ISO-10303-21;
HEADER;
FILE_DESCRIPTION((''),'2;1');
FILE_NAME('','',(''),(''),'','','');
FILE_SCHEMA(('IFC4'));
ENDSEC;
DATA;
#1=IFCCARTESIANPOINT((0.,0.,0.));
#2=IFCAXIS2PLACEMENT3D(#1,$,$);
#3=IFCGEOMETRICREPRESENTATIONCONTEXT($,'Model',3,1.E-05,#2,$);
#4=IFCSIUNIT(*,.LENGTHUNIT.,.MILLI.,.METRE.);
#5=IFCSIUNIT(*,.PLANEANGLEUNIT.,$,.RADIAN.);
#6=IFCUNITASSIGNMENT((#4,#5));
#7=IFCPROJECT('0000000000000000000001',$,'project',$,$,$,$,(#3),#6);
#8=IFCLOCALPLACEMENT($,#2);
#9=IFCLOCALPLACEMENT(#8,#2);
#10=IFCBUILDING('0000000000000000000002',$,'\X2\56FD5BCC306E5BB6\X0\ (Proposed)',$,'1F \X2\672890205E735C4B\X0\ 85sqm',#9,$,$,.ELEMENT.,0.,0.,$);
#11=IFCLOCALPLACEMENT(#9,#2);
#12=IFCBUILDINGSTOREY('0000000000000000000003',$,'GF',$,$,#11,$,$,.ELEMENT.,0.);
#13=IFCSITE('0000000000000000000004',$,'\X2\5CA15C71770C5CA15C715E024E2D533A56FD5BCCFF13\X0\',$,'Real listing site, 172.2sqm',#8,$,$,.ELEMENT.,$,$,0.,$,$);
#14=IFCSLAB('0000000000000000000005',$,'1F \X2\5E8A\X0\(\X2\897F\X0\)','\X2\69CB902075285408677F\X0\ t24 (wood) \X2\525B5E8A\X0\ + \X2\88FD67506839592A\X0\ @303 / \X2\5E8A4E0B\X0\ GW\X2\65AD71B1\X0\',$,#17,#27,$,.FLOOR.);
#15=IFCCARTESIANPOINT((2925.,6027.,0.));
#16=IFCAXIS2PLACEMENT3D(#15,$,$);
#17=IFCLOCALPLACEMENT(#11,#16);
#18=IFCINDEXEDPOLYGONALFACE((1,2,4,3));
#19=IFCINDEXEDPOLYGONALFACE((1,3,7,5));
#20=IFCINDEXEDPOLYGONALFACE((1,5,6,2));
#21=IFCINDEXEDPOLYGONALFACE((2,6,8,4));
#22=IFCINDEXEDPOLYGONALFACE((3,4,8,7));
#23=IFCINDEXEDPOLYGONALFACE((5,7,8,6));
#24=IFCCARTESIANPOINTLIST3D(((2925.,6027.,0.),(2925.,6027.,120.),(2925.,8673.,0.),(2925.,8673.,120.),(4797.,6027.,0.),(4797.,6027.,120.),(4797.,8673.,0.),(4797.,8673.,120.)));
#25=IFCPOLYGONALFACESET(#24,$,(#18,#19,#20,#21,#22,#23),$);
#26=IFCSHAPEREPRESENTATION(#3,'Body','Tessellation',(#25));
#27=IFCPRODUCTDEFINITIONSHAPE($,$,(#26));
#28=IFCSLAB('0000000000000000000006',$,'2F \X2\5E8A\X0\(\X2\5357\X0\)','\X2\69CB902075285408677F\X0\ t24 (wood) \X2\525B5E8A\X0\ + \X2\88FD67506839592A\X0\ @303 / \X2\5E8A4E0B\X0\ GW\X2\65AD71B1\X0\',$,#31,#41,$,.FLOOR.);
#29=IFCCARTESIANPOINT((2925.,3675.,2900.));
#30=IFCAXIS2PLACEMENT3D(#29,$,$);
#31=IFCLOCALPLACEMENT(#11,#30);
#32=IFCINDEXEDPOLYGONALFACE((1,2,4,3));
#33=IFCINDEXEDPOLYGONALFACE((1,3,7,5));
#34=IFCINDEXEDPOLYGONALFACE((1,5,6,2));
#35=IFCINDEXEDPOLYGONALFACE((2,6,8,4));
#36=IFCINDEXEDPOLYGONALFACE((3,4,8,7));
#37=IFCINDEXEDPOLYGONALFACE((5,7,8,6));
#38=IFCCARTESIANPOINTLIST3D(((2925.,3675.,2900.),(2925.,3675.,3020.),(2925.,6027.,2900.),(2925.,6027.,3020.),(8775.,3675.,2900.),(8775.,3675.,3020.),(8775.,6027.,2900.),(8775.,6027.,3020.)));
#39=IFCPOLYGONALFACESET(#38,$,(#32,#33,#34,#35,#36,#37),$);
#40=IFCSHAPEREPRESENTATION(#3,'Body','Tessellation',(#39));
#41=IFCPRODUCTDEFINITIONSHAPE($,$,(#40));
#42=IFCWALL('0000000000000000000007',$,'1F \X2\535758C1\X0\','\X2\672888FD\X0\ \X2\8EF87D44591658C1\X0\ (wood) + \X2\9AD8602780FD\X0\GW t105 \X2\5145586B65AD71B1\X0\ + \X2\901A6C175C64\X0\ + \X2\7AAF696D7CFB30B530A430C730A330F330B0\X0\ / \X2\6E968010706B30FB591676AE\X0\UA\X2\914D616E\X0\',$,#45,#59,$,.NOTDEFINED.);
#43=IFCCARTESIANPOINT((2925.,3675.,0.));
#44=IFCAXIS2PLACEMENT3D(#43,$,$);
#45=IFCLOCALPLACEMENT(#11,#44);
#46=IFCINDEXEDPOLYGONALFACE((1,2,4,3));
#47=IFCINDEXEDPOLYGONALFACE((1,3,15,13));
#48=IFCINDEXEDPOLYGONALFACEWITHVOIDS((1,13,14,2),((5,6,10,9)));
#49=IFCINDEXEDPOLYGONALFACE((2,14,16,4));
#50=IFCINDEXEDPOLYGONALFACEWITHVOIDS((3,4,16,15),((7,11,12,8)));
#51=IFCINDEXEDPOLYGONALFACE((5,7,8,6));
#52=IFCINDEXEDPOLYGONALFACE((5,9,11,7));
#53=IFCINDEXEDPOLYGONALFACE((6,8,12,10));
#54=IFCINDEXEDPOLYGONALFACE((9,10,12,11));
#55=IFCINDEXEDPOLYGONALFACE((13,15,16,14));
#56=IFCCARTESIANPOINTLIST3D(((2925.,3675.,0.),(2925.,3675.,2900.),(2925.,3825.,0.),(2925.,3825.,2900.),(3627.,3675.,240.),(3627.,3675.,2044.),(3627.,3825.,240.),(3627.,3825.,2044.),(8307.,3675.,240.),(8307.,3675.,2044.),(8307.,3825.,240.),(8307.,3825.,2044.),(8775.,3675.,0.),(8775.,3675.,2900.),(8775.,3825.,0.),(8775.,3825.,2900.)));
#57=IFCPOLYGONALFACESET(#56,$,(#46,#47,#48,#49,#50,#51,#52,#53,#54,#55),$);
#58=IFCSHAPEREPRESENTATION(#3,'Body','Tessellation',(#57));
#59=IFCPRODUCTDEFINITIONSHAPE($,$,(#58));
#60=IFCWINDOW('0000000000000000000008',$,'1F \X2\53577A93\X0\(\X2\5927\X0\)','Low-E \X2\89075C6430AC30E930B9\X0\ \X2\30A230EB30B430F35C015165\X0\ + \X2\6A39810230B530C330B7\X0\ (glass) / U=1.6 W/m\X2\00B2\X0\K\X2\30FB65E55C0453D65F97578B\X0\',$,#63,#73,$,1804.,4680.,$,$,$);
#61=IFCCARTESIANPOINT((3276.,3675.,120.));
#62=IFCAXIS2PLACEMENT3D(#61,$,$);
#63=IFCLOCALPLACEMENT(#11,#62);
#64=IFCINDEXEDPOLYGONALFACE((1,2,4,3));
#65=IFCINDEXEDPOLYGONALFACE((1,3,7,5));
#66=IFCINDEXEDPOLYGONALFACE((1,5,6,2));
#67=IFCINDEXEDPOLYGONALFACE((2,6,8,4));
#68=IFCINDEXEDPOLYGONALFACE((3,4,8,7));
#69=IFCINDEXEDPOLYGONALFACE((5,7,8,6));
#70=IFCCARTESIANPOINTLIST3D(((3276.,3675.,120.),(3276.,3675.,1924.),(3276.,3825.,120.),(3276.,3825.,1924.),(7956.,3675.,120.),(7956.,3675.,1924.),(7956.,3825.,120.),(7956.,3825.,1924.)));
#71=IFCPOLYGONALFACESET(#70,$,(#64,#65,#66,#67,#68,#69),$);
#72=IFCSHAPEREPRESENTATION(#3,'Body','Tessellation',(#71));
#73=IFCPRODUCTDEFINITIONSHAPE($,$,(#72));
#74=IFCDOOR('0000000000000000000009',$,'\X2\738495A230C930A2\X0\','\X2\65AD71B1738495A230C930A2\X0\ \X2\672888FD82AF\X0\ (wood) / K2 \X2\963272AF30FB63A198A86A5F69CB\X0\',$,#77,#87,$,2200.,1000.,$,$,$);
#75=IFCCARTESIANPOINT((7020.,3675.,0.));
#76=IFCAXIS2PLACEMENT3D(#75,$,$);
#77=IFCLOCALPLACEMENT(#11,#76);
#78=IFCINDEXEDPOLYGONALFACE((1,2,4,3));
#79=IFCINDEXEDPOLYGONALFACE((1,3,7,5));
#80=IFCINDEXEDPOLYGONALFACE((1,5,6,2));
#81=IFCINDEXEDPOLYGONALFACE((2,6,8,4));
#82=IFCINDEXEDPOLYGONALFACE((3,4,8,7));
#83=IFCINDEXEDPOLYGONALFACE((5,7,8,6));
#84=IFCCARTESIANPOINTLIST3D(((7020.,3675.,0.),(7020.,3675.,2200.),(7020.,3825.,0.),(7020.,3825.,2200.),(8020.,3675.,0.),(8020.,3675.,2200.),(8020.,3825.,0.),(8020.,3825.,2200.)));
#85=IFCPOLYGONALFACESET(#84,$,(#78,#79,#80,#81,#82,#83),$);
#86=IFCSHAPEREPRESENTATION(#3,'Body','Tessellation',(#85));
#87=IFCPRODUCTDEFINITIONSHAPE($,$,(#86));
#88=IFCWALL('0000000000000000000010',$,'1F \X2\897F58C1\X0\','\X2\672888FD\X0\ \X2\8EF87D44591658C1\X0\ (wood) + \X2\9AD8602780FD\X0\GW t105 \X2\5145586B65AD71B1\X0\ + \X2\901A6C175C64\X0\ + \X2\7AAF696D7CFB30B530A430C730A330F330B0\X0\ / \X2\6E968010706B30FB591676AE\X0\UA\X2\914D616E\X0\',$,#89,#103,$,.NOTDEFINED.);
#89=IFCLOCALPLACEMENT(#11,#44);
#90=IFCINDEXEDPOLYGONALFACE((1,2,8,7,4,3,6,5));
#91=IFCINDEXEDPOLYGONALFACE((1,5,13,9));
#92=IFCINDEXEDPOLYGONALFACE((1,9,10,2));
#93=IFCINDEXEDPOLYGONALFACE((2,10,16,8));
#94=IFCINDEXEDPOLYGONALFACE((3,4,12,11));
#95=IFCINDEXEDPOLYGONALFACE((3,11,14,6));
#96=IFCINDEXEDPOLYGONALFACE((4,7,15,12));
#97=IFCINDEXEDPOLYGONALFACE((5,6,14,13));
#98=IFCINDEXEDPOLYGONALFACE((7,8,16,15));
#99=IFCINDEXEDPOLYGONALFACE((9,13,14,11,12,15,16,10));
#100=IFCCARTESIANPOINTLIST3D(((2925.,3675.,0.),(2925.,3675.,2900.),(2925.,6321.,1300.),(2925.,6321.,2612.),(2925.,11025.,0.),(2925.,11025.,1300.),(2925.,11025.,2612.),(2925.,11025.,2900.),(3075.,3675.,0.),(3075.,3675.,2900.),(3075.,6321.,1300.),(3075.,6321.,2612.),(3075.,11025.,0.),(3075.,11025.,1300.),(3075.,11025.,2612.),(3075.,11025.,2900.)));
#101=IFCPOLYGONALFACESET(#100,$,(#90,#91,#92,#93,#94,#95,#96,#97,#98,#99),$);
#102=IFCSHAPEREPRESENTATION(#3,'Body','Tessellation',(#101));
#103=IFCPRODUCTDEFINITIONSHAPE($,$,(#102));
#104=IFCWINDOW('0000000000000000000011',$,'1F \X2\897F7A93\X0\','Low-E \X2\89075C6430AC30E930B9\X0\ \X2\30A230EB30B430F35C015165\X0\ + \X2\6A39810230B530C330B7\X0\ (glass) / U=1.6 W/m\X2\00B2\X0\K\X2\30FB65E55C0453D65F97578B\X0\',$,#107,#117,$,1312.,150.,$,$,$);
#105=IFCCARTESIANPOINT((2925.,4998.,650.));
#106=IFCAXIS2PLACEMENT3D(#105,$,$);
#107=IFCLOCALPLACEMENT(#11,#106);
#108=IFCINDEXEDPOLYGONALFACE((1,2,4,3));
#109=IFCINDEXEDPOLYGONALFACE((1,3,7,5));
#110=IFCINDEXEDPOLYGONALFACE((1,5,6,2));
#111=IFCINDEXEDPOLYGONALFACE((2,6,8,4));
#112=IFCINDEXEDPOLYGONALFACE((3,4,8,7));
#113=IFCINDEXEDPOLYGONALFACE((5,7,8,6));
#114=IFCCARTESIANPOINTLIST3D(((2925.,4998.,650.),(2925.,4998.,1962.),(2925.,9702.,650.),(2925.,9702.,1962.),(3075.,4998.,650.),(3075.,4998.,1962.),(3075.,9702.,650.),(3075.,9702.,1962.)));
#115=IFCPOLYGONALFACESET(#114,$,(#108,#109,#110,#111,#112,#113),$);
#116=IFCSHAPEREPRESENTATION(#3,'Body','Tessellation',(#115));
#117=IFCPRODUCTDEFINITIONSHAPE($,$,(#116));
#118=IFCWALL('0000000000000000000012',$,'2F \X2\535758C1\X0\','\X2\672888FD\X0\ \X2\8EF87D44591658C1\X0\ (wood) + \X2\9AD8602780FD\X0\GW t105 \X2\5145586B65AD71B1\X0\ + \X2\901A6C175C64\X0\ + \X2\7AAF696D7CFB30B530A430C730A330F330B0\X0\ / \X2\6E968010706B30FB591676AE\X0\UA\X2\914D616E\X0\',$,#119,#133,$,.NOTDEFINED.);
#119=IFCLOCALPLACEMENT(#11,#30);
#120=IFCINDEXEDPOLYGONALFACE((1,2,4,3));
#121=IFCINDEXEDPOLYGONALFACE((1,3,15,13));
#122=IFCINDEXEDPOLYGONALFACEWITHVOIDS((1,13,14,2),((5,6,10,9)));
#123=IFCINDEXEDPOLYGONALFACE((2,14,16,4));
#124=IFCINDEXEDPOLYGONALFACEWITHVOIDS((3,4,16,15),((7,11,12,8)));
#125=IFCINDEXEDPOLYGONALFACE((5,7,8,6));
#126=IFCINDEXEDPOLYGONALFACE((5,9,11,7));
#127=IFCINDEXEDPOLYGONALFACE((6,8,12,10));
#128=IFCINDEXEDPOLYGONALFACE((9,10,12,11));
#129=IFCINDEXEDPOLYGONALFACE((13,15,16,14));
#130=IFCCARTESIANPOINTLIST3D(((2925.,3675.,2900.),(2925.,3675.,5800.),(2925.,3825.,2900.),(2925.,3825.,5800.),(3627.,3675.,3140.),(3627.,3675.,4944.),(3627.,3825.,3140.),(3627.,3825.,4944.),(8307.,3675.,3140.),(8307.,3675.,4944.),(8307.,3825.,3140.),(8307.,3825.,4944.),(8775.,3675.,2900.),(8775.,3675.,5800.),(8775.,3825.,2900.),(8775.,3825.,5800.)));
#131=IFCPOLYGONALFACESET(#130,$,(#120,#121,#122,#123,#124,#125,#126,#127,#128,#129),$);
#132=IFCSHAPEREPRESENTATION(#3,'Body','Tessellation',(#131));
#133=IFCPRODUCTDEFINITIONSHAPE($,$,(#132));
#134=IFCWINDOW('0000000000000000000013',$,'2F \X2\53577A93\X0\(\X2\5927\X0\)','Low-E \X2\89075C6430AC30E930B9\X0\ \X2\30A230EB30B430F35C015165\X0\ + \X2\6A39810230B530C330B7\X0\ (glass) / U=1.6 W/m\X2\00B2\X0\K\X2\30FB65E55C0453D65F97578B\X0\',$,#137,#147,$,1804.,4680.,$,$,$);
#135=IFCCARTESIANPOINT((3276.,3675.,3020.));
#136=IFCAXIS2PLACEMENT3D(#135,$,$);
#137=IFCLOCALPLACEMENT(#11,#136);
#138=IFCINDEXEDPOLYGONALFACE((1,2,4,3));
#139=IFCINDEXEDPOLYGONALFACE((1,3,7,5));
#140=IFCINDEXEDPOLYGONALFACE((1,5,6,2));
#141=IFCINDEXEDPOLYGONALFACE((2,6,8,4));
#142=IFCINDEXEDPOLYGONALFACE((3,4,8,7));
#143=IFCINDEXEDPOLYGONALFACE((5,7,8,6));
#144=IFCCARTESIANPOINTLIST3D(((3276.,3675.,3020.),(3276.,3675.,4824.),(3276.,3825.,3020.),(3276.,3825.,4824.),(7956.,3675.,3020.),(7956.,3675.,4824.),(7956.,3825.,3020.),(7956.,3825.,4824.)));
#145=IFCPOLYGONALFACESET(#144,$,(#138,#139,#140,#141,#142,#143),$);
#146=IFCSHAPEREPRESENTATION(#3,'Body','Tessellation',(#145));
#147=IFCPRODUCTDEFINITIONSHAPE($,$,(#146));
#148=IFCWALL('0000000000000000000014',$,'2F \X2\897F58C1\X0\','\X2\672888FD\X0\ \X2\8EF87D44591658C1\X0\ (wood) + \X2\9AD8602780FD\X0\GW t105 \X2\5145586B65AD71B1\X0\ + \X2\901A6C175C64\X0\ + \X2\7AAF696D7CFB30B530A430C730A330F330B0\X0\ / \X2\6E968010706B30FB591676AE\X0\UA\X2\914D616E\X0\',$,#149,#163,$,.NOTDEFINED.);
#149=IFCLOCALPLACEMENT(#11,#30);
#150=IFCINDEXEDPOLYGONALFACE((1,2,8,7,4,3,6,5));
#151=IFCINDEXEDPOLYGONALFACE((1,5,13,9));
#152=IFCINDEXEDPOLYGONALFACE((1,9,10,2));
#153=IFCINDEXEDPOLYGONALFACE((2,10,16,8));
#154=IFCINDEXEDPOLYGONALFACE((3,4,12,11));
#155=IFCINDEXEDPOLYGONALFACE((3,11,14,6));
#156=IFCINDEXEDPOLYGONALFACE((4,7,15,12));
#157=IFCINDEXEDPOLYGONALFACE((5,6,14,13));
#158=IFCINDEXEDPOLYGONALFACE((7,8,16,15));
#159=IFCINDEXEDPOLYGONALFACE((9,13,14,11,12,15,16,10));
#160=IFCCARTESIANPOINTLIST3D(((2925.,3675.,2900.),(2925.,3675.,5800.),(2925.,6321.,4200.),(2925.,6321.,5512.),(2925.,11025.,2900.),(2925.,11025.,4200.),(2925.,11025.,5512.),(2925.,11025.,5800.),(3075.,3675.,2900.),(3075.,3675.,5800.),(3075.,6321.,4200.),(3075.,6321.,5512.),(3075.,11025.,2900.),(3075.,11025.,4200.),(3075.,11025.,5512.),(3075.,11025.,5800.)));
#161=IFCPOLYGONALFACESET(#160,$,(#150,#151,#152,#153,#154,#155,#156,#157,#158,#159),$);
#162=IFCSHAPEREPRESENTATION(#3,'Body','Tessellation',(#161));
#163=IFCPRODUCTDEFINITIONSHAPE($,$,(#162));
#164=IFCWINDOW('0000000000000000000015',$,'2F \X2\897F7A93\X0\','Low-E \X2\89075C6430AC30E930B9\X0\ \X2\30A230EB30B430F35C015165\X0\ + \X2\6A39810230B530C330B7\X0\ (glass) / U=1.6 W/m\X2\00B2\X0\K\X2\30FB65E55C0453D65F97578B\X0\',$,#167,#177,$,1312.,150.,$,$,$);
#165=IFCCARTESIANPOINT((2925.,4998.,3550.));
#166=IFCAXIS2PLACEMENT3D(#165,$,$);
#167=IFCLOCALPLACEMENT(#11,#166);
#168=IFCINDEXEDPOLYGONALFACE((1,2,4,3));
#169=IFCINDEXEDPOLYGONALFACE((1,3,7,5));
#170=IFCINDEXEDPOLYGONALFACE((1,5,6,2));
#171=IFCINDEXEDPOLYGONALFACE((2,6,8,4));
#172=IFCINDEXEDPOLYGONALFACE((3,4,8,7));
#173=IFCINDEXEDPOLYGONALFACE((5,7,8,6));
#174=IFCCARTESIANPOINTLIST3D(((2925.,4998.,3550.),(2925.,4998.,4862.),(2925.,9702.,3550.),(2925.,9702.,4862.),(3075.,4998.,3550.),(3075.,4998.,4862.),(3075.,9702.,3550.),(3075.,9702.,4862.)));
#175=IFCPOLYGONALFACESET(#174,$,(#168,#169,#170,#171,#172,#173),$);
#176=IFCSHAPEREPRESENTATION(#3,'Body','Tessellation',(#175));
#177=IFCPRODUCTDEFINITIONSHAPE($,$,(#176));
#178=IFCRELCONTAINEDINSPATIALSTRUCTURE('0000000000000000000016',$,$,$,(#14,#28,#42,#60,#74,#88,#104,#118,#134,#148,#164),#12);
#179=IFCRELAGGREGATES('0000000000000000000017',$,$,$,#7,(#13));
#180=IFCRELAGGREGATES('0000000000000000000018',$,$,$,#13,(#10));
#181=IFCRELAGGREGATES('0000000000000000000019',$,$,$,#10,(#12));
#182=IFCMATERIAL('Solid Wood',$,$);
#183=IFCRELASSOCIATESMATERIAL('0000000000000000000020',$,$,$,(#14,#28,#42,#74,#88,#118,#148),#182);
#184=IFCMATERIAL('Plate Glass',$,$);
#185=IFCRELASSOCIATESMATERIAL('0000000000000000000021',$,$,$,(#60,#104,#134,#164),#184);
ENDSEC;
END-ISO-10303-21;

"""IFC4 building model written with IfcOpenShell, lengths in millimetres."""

from ifc_helpers import new_model, si_unit, frame, frame_2d, origin, place, context, project, spatial, rectangle, extrude, material, element, fill, save


model = new_model("IFC4")

# Units and contexts
model_context = context("Model", 3, precision=1e-05, world=origin())
ifc_project = project(units=[si_unit("LENGTHUNIT", "METRE", prefix="MILLI"), si_unit("PLANEANGLEUNIT", "RADIAN")], contexts=[model_context])

# Site, building, storey
site_placement = place(None, origin())
site = spatial("IfcSite", under=ifc_project, at=site_placement, Name="岡山県岡山市中区国富３", ObjectType="Real listing site, 172.2sqm", CompositionType="ELEMENT", RefElevation=0.0)
building_placement = place(site_placement, origin())
building = spatial("IfcBuilding", under=site, at=building_placement, Name="国富の家 (Proposed)", ObjectType="1F 木造平屋 85sqm", CompositionType="ELEMENT", ElevationOfRefHeight=0.0, ElevationOfTerrain=0.0)
storey_placement = place(building_placement, origin())
storey = spatial("IfcBuildingStorey", under=building, at=storey_placement, Name="GF", CompositionType="ELEMENT", Elevation=0.0)

# Slabs
ifc_material_1 = material(Name="Solid Wood")
slab_1_placement = place(storey_placement, frame((2925.0, 6027.0, 0.0)))
element("IfcSlab", 1, at=slab_1_placement, inside=storey, material=ifc_material_1, Name="1F 床(西)", Description="構造用合板 t24 (wood) 剛床 + 製材根太 @303 / 床下 GW断熱", PredefinedType="FLOOR", context=model_context, shape_type="SweptSolid", body=[
    extrude(rectangle(XDim=1872.0, YDim=2646.0, at=frame_2d((936.0, 1323.0))), frame((2925.0, 6027.0, 0.0)), (0.0, 0.0, 1.0), 120.0),
])
slab_2_placement = place(storey_placement, frame((2925.0, 3675.0, 2900.0)))
element("IfcSlab", 2, at=slab_2_placement, inside=storey, material=ifc_material_1, Name="2F 床(南)", Description="構造用合板 t24 (wood) 剛床 + 製材根太 @303 / 床下 GW断熱", PredefinedType="FLOOR", context=model_context, shape_type="SweptSolid", body=[
    extrude(rectangle(XDim=5850.0, YDim=2352.0, at=frame_2d((2925.0, 1176.0))), frame((2925.0, 3675.0, 2900.0)), (0.0, 0.0, 1.0), 120.0),
])

# Wall, openings, window, door
wall_1_placement = place(storey_placement, frame((2925.0, 3675.0, 0.0)))
wall_1 = element("IfcWall", 3, at=wall_1_placement, inside=storey, material=ifc_material_1, Name="1F 南壁", Description="木製 軸組外壁 (wood) + 高性能GW t105 充填断熱 + 通気層 + 窯業系サイディング / 準耐火・外皮UA配慮", PredefinedType="NOTDEFINED", context=model_context, shape_type="SweptSolid", body=[
    extrude(rectangle(XDim=5850.0, YDim=150.0, at=frame_2d((2925.0, 75.0))), frame((2925.0, 3675.0, 0.0)), (0.0, 0.0, 1.0), 2900.0),
])
opening_1_placement = place(storey_placement, frame((3276.0, 3675.0, 120.0)))
opening_1 = element("IfcOpeningElement", 4, at=opening_1_placement, cuts=wall_1, PredefinedType="NOTDEFINED", context=model_context, shape_type="SweptSolid", body=[
    extrude(rectangle(XDim=4680.0, YDim=150.0, at=frame_2d((2340.0, 75.0))), frame((3276.0, 3675.0, 120.0)), (0.0, 0.0, 1.0), 1804.0),
])
opening_2_placement = place(storey_placement, frame((7020.0, 3675.0, 0.0)))
opening_2 = element("IfcOpeningElement", 5, at=opening_2_placement, cuts=wall_1, PredefinedType="NOTDEFINED", context=model_context, shape_type="SweptSolid", body=[
    extrude(rectangle(XDim=1000.0, YDim=150.0, at=frame_2d((500.0, 75.0))), frame((7020.0, 3675.0, 0.0)), (0.0, 0.0, 1.0), 2200.0),
])
ifc_material_2 = material(Name="Plate Glass")
window_1_placement = place(storey_placement, frame((3276.0, 3675.0, 120.0)))
window_1 = element("IfcWindow", 6, at=window_1_placement, inside=storey, material=ifc_material_2, Name="1F 南窓(大)", Description="Low-E 複層ガラス アルゴン封入 + 樹脂サッシ (glass) / U=1.6 W/m²K・日射取得型", OverallHeight=1804.0, OverallWidth=4680.0, context=model_context, shape_type="SweptSolid", body=[
    extrude(rectangle(XDim=4680.0, YDim=150.0, at=frame_2d((2340.0, 75.0))), frame((3276.0, 3675.0, 120.0)), (0.0, 0.0, 1.0), 1804.0),
])
fill(opening_1, window_1)
door_placement = place(storey_placement, frame((7020.0, 3675.0, 0.0)))
door = element("IfcDoor", 7, at=door_placement, inside=storey, material=ifc_material_1, Name="玄関ドア", Description="断熱玄関ドア 木製芯 (wood) / K2 防犯・採風機構", OverallHeight=2200.0, OverallWidth=1000.0, context=model_context, shape_type="SweptSolid", body=[
    extrude(rectangle(XDim=1000.0, YDim=150.0, at=frame_2d((500.0, 75.0))), frame((7020.0, 3675.0, 0.0)), (0.0, 0.0, 1.0), 2200.0),
])
fill(opening_2, door)

# Walls, openings, windows
wall_2_placement = place(storey_placement, frame((2925.0, 3675.0, 0.0)))
wall_2 = element("IfcWall", 8, at=wall_2_placement, inside=storey, material=ifc_material_1, Name="1F 西壁", Description="木製 軸組外壁 (wood) + 高性能GW t105 充填断熱 + 通気層 + 窯業系サイディング / 準耐火・外皮UA配慮", PredefinedType="NOTDEFINED", context=model_context, shape_type="SweptSolid", body=[
    extrude(rectangle(XDim=150.0, YDim=7350.0, at=frame_2d((75.0, 3675.0))), frame((2925.0, 3675.0, 0.0)), (0.0, 0.0, 1.0), 2900.0),
])
opening_3_placement = place(storey_placement, frame((2925.0, 4998.0, 650.0)))
opening_3 = element("IfcOpeningElement", 9, at=opening_3_placement, cuts=wall_2, PredefinedType="NOTDEFINED", context=model_context, shape_type="SweptSolid", body=[
    extrude(rectangle(XDim=150.0, YDim=4704.0, at=frame_2d((75.0, 2352.0))), frame((2925.0, 4998.0, 650.0)), (0.0, 0.0, 1.0), 1312.0),
])
window_2_placement = place(storey_placement, frame((2925.0, 4998.0, 650.0)))
window_2 = element("IfcWindow", 10, at=window_2_placement, inside=storey, material=ifc_material_2, Name="1F 西窓", Description="Low-E 複層ガラス アルゴン封入 + 樹脂サッシ (glass) / U=1.6 W/m²K・日射取得型", OverallHeight=1312.0, OverallWidth=150.0, context=model_context, shape_type="SweptSolid", body=[
    extrude(rectangle(XDim=150.0, YDim=4704.0, at=frame_2d((75.0, 2352.0))), frame((2925.0, 4998.0, 650.0)), (0.0, 0.0, 1.0), 1312.0),
])
fill(opening_3, window_2)
wall_3_placement = place(storey_placement, frame((2925.0, 3675.0, 2900.0)))
wall_3 = element("IfcWall", 11, at=wall_3_placement, inside=storey, material=ifc_material_1, Name="2F 南壁", Description="木製 軸組外壁 (wood) + 高性能GW t105 充填断熱 + 通気層 + 窯業系サイディング / 準耐火・外皮UA配慮", PredefinedType="NOTDEFINED", context=model_context, shape_type="SweptSolid", body=[
    extrude(rectangle(XDim=5850.0, YDim=150.0, at=frame_2d((2925.0, 75.0))), frame((2925.0, 3675.0, 2900.0)), (0.0, 0.0, 1.0), 2900.0),
])
opening_4_placement = place(storey_placement, frame((3276.0, 3675.0, 3020.0)))
opening_4 = element("IfcOpeningElement", 12, at=opening_4_placement, cuts=wall_3, PredefinedType="NOTDEFINED", context=model_context, shape_type="SweptSolid", body=[
    extrude(rectangle(XDim=4680.0, YDim=150.0, at=frame_2d((2340.0, 75.0))), frame((3276.0, 3675.0, 3020.0)), (0.0, 0.0, 1.0), 1804.0),
])
window_3_placement = place(storey_placement, frame((3276.0, 3675.0, 3020.0)))
window_3 = element("IfcWindow", 13, at=window_3_placement, inside=storey, material=ifc_material_2, Name="2F 南窓(大)", Description="Low-E 複層ガラス アルゴン封入 + 樹脂サッシ (glass) / U=1.6 W/m²K・日射取得型", OverallHeight=1804.0, OverallWidth=4680.0, context=model_context, shape_type="SweptSolid", body=[
    extrude(rectangle(XDim=4680.0, YDim=150.0, at=frame_2d((2340.0, 75.0))), frame((3276.0, 3675.0, 3020.0)), (0.0, 0.0, 1.0), 1804.0),
])
fill(opening_4, window_3)
wall_4_placement = place(storey_placement, frame((2925.0, 3675.0, 2900.0)))
wall_4 = element("IfcWall", 14, at=wall_4_placement, inside=storey, material=ifc_material_1, Name="2F 西壁", Description="木製 軸組外壁 (wood) + 高性能GW t105 充填断熱 + 通気層 + 窯業系サイディング / 準耐火・外皮UA配慮", PredefinedType="NOTDEFINED", context=model_context, shape_type="SweptSolid", body=[
    extrude(rectangle(XDim=150.0, YDim=7350.0, at=frame_2d((75.0, 3675.0))), frame((2925.0, 3675.0, 2900.0)), (0.0, 0.0, 1.0), 2900.0),
])
opening_5_placement = place(storey_placement, frame((2925.0, 4998.0, 3550.0)))
opening_5 = element("IfcOpeningElement", 15, at=opening_5_placement, cuts=wall_4, PredefinedType="NOTDEFINED", context=model_context, shape_type="SweptSolid", body=[
    extrude(rectangle(XDim=150.0, YDim=4704.0, at=frame_2d((75.0, 2352.0))), frame((2925.0, 4998.0, 3550.0)), (0.0, 0.0, 1.0), 1312.0),
])
window_4_placement = place(storey_placement, frame((2925.0, 4998.0, 3550.0)))
window_4 = element("IfcWindow", 16, at=window_4_placement, inside=storey, material=ifc_material_2, Name="2F 西窓", Description="Low-E 複層ガラス アルゴン封入 + 樹脂サッシ (glass) / U=1.6 W/m²K・日射取得型", OverallHeight=1312.0, OverallWidth=150.0, context=model_context, shape_type="SweptSolid", body=[
    extrude(rectangle(XDim=150.0, YDim=4704.0, at=frame_2d((75.0, 2352.0))), frame((2925.0, 4998.0, 3550.0)), (0.0, 0.0, 1.0), 1312.0),
])
fill(opening_5, window_4)

save(model, "model.ifc")
